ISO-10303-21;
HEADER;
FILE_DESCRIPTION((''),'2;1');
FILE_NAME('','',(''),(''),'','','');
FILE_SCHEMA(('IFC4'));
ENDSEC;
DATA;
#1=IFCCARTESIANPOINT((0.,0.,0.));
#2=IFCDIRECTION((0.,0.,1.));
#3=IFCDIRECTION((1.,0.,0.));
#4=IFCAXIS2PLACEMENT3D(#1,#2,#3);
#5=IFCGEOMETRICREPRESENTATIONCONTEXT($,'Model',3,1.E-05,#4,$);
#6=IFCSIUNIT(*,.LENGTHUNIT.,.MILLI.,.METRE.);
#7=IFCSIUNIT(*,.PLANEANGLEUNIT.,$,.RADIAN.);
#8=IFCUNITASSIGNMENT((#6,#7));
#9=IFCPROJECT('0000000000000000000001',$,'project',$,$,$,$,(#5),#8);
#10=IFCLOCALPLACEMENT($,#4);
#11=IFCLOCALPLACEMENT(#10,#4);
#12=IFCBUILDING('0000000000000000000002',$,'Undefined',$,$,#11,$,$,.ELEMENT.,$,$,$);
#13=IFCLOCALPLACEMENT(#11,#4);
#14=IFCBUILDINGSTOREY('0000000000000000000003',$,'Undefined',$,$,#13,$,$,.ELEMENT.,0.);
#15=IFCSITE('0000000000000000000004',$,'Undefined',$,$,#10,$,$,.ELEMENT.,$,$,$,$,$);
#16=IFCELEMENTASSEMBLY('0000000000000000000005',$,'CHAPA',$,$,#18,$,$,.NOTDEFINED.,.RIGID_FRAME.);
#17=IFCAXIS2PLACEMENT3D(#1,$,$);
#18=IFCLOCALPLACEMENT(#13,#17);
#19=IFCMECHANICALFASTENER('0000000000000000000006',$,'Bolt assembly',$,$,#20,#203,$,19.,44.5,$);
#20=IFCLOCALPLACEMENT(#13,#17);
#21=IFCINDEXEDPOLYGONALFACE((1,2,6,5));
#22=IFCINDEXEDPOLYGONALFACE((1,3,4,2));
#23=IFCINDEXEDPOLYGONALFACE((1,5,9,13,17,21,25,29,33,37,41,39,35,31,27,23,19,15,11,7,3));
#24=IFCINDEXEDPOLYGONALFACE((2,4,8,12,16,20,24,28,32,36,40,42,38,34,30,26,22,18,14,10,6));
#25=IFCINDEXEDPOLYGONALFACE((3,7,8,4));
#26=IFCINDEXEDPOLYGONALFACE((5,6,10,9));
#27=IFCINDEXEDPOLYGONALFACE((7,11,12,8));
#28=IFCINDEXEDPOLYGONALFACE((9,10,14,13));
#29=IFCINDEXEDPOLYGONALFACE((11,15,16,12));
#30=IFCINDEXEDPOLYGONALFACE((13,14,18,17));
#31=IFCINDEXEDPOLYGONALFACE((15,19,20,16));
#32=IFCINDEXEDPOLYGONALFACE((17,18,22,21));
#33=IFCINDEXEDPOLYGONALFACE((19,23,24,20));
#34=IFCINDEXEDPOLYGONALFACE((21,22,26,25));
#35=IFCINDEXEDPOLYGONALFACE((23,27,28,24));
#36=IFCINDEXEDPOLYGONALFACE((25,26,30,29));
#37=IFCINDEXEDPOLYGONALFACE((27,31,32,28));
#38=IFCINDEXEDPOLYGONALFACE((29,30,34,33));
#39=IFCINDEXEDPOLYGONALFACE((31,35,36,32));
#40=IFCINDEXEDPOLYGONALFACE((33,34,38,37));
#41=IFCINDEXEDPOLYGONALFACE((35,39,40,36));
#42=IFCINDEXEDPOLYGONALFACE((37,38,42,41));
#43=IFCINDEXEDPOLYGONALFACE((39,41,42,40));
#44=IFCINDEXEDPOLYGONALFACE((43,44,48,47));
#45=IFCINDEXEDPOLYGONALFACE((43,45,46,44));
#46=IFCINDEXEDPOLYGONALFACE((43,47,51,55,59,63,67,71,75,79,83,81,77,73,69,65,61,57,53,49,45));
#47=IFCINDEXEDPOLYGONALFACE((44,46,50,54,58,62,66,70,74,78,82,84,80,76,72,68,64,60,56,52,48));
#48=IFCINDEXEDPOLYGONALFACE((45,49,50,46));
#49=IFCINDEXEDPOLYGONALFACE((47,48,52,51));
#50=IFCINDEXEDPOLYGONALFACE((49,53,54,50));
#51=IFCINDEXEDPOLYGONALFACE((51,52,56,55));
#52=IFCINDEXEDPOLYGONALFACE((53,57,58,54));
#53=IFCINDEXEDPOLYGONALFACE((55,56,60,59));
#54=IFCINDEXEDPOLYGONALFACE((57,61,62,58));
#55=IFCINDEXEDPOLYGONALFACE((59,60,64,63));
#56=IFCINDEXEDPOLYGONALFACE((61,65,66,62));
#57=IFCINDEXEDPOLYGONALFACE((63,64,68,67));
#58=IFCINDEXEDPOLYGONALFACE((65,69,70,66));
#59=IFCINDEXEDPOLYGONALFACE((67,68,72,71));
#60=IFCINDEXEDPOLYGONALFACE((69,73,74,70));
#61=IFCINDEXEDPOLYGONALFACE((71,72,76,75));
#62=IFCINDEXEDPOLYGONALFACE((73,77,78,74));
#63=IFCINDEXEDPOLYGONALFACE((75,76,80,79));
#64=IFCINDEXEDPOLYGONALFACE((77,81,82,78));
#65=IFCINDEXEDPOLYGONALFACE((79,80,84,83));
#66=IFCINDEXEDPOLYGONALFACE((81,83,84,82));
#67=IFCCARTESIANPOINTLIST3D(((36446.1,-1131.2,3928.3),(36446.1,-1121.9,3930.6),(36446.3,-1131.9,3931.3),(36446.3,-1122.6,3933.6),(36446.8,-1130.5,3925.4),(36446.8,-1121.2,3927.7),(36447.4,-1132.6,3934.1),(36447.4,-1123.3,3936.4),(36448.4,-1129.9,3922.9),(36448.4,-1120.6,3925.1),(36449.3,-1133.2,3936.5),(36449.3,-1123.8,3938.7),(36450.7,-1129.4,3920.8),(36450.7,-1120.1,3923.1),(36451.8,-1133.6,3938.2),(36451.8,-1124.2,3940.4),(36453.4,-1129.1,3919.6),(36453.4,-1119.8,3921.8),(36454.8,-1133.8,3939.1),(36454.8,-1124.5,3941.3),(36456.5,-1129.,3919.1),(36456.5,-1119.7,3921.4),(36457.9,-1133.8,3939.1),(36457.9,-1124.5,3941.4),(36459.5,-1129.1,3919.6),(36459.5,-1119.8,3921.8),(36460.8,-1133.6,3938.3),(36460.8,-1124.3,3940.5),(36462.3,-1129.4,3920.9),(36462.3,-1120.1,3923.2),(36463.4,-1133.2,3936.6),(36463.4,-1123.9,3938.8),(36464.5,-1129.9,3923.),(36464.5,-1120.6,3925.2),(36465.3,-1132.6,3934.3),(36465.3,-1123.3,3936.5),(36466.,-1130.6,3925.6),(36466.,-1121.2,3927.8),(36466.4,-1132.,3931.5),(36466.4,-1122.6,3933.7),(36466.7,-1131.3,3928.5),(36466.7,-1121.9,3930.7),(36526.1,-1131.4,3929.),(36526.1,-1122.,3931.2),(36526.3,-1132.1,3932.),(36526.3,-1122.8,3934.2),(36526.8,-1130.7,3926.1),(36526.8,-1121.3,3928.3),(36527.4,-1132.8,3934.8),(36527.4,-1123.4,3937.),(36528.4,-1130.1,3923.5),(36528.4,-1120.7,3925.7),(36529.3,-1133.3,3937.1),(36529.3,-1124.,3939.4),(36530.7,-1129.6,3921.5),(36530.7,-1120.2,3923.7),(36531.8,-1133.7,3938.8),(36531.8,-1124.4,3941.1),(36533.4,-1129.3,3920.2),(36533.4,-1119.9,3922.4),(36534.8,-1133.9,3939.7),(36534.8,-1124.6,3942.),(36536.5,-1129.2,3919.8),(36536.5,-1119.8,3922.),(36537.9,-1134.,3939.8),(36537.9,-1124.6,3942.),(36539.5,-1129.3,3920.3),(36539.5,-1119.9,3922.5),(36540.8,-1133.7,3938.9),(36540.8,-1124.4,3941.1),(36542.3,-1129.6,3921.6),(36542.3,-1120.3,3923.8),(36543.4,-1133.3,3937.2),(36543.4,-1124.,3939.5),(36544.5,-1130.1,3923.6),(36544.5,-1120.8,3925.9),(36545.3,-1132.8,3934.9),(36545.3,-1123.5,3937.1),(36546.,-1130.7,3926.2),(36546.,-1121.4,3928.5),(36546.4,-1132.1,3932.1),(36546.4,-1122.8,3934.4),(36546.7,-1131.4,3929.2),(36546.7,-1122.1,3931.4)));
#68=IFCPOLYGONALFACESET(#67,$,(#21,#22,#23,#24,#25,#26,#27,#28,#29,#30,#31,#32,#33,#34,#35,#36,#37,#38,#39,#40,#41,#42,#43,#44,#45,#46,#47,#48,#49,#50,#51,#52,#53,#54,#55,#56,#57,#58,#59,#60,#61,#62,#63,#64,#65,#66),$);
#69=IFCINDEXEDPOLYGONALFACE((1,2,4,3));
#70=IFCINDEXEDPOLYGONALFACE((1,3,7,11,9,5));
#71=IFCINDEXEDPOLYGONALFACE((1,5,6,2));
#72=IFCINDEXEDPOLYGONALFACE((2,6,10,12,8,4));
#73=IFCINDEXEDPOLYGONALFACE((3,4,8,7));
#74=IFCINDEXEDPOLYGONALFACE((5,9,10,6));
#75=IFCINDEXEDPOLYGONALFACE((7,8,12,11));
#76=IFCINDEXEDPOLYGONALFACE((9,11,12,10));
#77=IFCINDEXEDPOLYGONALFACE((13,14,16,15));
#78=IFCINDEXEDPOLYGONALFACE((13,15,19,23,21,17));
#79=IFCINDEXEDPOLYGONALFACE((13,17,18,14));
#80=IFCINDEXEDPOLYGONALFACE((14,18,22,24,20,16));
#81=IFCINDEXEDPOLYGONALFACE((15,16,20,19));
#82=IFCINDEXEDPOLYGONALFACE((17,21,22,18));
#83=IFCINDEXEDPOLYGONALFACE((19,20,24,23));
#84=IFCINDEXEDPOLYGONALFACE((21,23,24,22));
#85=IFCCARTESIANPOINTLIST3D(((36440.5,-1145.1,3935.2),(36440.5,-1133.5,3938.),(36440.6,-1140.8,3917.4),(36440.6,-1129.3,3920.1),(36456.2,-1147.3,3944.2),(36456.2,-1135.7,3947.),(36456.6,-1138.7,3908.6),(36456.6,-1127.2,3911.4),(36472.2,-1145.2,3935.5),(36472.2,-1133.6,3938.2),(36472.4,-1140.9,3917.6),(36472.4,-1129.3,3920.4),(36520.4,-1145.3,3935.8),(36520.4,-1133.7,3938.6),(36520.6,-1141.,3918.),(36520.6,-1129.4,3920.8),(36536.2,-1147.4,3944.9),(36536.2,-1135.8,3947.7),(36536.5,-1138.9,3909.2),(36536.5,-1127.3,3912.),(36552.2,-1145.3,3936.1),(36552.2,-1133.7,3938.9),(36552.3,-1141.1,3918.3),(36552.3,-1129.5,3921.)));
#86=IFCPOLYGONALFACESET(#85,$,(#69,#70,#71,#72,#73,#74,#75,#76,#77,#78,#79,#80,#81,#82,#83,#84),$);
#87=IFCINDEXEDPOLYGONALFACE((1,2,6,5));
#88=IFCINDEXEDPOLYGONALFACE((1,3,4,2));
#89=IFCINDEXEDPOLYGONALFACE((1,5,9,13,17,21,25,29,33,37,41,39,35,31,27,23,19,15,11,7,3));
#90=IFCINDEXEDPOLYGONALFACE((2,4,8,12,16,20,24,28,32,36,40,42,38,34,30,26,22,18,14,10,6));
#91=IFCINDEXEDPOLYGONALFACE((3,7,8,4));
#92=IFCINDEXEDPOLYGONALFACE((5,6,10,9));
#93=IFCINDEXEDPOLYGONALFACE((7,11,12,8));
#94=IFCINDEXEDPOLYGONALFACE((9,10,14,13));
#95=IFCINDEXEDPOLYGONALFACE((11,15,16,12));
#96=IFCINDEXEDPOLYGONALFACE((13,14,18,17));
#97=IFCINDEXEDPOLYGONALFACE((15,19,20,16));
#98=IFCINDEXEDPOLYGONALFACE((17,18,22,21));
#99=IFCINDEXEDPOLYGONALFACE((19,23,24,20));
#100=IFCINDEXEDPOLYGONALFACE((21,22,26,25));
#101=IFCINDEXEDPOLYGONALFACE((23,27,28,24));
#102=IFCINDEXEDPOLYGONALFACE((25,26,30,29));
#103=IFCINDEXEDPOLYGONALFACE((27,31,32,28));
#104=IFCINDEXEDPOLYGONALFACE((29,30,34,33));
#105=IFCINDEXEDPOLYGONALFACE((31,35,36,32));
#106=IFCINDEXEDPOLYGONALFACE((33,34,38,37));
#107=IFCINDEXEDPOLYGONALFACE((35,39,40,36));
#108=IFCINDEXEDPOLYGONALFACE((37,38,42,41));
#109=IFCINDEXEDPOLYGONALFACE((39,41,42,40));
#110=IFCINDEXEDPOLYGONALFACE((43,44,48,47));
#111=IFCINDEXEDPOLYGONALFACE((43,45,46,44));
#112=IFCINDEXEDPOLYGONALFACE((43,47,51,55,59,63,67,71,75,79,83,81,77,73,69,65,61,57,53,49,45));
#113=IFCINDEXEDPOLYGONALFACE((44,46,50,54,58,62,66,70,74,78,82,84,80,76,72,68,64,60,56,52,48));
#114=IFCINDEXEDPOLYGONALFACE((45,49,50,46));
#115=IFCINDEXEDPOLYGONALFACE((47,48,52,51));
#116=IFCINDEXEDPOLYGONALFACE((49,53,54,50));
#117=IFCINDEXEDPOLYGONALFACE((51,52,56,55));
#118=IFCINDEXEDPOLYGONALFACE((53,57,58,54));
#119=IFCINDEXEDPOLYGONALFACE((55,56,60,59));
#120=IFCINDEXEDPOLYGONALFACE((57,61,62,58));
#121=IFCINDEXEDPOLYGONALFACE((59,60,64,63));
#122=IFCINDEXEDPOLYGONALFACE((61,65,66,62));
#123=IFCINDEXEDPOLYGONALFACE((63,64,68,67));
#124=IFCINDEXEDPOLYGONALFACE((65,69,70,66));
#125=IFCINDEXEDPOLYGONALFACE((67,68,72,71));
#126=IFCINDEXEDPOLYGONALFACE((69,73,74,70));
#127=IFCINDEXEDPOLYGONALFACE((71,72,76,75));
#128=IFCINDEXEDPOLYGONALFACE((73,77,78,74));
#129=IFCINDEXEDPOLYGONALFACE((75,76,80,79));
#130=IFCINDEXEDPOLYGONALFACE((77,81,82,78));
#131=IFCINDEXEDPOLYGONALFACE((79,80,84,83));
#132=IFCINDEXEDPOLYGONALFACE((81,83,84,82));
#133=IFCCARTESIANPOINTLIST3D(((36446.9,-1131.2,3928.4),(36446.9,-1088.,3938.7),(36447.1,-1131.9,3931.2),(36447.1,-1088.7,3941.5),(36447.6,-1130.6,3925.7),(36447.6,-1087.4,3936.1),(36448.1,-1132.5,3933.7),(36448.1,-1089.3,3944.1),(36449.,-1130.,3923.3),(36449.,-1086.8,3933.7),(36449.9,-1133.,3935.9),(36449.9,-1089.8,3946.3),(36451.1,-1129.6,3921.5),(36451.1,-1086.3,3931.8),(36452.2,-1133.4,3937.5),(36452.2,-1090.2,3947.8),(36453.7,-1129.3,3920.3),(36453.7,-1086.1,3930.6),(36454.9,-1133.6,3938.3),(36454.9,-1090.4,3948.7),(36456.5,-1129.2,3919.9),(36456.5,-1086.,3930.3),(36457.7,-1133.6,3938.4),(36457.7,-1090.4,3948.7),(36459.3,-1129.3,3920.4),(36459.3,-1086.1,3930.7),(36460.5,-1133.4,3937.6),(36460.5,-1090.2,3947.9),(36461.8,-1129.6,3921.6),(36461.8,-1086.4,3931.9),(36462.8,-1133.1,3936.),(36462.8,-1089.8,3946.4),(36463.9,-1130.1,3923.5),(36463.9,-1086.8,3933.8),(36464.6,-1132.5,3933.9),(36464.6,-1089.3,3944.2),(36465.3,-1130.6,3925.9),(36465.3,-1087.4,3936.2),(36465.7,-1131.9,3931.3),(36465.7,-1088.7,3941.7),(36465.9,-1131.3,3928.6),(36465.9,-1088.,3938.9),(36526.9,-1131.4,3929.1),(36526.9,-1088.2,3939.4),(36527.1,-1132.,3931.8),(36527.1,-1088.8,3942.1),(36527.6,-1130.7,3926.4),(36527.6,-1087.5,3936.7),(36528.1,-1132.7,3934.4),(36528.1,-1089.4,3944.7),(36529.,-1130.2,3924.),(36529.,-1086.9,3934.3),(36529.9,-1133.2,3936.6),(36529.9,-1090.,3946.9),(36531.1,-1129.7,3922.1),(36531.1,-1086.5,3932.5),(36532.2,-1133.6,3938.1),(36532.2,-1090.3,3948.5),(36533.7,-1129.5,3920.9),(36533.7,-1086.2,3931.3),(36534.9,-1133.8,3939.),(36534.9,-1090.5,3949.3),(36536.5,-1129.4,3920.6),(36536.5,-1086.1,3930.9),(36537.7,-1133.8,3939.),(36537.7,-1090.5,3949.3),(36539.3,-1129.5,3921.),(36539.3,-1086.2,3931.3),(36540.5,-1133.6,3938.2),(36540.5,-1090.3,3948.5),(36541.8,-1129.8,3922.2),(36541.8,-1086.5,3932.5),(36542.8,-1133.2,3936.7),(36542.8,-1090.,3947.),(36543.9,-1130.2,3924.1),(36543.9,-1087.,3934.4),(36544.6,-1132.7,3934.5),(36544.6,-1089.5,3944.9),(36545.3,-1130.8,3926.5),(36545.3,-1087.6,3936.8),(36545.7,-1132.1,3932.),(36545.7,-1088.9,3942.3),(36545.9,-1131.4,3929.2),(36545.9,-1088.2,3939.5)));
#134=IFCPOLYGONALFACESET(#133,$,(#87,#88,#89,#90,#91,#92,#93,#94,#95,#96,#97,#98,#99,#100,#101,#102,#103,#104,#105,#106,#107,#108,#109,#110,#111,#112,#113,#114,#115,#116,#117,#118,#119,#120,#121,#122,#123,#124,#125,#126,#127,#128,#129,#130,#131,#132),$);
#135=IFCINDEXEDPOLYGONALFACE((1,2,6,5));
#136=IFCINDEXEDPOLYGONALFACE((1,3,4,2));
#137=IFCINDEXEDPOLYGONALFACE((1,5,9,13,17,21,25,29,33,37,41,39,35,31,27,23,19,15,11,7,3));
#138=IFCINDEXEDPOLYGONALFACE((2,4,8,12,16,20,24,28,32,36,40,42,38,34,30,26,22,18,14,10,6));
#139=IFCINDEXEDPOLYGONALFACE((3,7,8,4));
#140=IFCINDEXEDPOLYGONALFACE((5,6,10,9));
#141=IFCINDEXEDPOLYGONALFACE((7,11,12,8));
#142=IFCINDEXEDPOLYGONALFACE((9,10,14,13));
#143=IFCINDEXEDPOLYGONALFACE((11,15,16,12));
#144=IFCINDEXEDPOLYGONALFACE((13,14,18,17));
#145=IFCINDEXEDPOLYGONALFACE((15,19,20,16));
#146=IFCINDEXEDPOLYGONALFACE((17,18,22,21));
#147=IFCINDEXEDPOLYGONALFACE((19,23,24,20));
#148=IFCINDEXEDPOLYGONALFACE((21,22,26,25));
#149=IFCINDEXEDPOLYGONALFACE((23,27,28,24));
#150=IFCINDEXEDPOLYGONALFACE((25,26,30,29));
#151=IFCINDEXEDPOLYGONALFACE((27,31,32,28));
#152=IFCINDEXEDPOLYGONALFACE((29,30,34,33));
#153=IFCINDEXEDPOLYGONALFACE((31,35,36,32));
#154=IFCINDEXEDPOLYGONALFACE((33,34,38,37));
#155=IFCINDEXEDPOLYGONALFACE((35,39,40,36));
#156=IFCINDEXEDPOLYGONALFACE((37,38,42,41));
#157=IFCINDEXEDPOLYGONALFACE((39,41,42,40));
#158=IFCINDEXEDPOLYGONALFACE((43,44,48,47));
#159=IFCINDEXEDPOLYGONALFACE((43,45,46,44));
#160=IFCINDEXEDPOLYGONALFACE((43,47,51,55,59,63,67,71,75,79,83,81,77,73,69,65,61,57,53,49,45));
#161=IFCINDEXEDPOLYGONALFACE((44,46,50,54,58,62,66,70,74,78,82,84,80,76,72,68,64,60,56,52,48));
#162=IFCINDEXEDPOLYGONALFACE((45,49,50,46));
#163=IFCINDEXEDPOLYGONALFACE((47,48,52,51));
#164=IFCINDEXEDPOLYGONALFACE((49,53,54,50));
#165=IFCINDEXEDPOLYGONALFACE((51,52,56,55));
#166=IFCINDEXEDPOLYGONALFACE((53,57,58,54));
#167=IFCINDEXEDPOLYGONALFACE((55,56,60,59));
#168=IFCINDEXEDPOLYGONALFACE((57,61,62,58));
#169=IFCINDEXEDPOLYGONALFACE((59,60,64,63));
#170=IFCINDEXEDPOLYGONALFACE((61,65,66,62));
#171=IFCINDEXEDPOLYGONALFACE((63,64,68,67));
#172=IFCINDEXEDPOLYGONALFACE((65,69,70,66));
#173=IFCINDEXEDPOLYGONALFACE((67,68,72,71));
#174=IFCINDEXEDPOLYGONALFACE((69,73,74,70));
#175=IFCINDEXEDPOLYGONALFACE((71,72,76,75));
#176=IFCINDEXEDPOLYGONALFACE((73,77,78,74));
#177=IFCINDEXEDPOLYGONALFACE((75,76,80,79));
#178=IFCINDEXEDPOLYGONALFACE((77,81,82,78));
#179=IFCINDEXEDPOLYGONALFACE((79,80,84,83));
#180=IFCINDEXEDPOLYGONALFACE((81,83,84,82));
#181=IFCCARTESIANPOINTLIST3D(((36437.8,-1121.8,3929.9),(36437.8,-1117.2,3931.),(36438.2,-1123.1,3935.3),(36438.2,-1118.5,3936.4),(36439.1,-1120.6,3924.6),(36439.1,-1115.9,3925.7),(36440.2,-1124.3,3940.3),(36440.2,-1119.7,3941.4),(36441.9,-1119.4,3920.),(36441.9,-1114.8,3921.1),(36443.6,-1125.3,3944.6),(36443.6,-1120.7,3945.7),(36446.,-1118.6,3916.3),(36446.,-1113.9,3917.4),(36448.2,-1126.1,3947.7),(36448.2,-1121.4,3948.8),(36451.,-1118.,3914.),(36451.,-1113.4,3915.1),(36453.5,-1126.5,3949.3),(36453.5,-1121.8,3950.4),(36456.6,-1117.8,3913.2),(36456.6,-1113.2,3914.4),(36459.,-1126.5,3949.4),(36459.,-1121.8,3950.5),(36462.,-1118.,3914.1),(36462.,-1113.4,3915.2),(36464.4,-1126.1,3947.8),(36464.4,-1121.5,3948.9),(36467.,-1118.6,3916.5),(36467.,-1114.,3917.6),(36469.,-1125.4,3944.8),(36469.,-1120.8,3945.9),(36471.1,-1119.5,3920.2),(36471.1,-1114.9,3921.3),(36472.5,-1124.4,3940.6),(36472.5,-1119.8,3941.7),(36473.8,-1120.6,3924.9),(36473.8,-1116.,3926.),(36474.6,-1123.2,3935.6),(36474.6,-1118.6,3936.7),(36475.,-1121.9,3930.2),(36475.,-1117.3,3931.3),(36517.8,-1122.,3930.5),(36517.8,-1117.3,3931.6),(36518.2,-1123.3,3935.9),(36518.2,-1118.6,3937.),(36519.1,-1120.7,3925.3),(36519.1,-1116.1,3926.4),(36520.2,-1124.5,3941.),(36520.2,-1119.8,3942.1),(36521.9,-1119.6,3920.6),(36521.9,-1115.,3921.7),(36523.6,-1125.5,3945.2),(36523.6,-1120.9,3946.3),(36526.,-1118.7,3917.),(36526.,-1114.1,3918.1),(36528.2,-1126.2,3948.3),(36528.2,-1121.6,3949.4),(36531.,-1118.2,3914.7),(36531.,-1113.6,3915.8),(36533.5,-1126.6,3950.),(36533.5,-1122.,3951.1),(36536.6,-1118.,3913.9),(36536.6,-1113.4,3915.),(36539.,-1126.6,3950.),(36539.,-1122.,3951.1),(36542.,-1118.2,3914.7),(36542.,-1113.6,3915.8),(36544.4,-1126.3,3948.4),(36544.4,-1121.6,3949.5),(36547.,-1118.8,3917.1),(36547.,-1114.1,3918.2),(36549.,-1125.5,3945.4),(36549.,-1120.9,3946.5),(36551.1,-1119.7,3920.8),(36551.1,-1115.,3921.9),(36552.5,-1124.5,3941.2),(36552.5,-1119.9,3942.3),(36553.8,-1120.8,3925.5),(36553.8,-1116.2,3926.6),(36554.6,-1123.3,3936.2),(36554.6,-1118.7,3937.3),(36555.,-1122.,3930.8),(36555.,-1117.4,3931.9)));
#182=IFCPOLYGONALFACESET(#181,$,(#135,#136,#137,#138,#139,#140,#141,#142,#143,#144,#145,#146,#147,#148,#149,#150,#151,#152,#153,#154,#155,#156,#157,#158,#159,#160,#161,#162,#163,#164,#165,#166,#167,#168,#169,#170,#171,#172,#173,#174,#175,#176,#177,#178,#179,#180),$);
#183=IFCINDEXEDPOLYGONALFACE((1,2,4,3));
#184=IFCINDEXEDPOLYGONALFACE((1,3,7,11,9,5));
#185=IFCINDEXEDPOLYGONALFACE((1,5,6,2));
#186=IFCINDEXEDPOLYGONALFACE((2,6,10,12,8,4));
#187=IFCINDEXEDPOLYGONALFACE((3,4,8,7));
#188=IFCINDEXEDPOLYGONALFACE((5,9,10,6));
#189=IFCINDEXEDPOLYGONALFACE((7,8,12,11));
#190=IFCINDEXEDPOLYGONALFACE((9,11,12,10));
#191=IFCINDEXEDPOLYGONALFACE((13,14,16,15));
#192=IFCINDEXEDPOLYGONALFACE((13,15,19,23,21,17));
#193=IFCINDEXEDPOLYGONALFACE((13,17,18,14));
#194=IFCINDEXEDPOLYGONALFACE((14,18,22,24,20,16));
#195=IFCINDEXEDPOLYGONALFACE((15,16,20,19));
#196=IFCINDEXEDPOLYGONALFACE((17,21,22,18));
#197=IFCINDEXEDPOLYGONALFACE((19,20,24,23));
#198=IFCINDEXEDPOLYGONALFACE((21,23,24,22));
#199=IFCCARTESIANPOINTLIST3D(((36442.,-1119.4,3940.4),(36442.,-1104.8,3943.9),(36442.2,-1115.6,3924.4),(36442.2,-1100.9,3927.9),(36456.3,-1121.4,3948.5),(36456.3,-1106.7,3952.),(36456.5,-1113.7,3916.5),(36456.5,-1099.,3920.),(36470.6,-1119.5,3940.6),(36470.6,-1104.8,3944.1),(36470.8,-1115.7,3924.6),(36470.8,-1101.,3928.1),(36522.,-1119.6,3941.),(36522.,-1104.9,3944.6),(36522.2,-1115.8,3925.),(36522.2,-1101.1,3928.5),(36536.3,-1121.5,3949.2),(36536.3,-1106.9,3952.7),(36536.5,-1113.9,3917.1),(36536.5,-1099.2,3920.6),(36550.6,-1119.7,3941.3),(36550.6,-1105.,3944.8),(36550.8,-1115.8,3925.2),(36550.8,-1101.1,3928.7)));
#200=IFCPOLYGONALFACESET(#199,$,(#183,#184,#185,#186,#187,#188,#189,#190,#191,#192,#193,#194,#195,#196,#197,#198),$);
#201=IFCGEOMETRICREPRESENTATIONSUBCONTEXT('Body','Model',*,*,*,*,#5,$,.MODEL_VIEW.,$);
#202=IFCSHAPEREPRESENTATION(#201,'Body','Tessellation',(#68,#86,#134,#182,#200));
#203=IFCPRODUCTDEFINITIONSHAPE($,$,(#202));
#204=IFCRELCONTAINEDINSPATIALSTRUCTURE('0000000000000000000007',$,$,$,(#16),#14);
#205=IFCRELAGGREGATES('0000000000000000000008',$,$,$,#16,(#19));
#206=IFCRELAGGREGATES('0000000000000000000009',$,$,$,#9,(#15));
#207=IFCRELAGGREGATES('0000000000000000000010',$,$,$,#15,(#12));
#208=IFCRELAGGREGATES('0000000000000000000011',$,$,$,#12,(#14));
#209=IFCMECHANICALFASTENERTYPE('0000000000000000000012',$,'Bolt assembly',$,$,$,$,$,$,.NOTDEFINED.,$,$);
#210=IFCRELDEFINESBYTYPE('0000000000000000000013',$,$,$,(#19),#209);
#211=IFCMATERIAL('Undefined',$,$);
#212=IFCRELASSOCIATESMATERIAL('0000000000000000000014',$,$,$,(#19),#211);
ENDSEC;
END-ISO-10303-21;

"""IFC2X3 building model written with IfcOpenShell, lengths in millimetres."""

from ifc_helpers import new_model, si_unit, frame, origin_with_axes, origin_2d_with_axis, place, context, subcontext, project, spatial, polyline, circle, outline, extrude, source, transform, mapped, material, type_object, element, aggregate, save


model = new_model("IFC2X3")

# Units and contexts
model_context = context("Model", 3, precision=1e-05, world=origin_with_axes())
body_context = subcontext(model_context, "Body", "Model", "MODEL_VIEW")
ifc_project = project(units=[si_unit("LENGTHUNIT", "METRE", prefix="MILLI"), si_unit("PLANEANGLEUNIT", "RADIAN")], contexts=[model_context])

# Site, building, storey
site_placement = place(None, origin_with_axes())
site = spatial("IfcSite", under=ifc_project, at=site_placement, Name="Undefined", CompositionType="ELEMENT")
building_placement = place(site_placement, origin_with_axes())
building = spatial("IfcBuilding", under=site, at=building_placement, Name="Undefined", CompositionType="ELEMENT")
storey_placement = place(building_placement, origin_with_axes())
storey = spatial("IfcBuildingStorey", under=building, at=storey_placement, Name="Undefined", CompositionType="ELEMENT", Elevation=0.0)

# Element assembly
assembly_1_placement = place(storey_placement, origin_with_axes())
assembly_1 = element("IfcElementAssembly", 1, at=assembly_1_placement, inside=storey, Name="CHAPA", AssemblyPlace="NOTDEFINED", PredefinedType="RIGID_FRAME")

# Shared definitions
ifc_material_1 = material(Name="Undefined")
mechanical_fastener_type = type_object("IfcMechanicalFastenerType", Name="Bolt assembly")

# Mechanical fastener
shared_shape_1 = source(origin_with_axes(), body_context, "Body", "SweptSolid", [
    extrude(circle(Radius=10.3, at=origin_2d_with_axis()), frame((0.0, 0.0, 0.0), z_axis=(0.0, 1.0, 0.0), x_axis=(1.0, 0.0, 0.0)), (0.0, 0.0, 1.0), 9.6),
    extrude(outline(polyline([(18.3, 0.0), (9.2, 15.9), (-9.2, 15.9), (-18.3, 0.0), (-9.2, -15.9), (9.2, -15.9), (18.3, 0.0)])), frame((0.0, -11.9, 0.0), z_axis=(0.0, 1.0, 0.0), x_axis=(1.0, 0.0, 0.0)), (0.0, 0.0, 1.0), 11.9),
    extrude(circle(Radius=9.5, at=origin_2d_with_axis()), frame((0.0, 0.0, 0.0), z_axis=(0.0, 1.0, 0.0), x_axis=(1.0, 0.0, 0.0)), (0.0, 0.0, 1.0), 44.5),
    extrude(circle(Radius=18.7, at=origin_2d_with_axis()), frame((0.0, 9.5, 0.0), z_axis=(0.0, 1.0, 0.0), x_axis=(1.0, 0.0, 0.0)), (0.0, 0.0, 1.0), 4.8),
    extrude(outline(polyline([(16.5, 0.0), (8.2, 14.3), (-8.2, 14.3), (-16.5, 0.0), (-8.2, -14.3), (8.2, -14.3), (16.5, 0.0)])), frame((0.0, 14.3, 0.0), z_axis=(0.0, 1.0, 0.0), x_axis=(1.0, 0.0, 0.0)), (0.0, 0.0, 1.0), 15.1),
])
mechanical_fastener_1_placement = place(assembly_1_placement, frame((36496.4, -1131.5, 3929.5), z_axis=(0.999966, -0.001918, 0.008027), x_axis=(0.008253, 0.23249, -0.972564)))
mechanical_fastener_1 = element("IfcMechanicalFastener", 2, at=mechanical_fastener_1_placement, type_object=mechanical_fastener_type, material=ifc_material_1, Name="Bolt assembly", NominalDiameter=19.0, NominalLength=44.5, context=body_context, shape_type="MappedRepresentation", body=[
    mapped(shared_shape_1, transform((0.0, 0.0, -40.0))),
    mapped(shared_shape_1, transform((0.0, 0.0, 40.0))),
])
aggregate(assembly_1, [mechanical_fastener_1])

save(model, "model.ifc")
